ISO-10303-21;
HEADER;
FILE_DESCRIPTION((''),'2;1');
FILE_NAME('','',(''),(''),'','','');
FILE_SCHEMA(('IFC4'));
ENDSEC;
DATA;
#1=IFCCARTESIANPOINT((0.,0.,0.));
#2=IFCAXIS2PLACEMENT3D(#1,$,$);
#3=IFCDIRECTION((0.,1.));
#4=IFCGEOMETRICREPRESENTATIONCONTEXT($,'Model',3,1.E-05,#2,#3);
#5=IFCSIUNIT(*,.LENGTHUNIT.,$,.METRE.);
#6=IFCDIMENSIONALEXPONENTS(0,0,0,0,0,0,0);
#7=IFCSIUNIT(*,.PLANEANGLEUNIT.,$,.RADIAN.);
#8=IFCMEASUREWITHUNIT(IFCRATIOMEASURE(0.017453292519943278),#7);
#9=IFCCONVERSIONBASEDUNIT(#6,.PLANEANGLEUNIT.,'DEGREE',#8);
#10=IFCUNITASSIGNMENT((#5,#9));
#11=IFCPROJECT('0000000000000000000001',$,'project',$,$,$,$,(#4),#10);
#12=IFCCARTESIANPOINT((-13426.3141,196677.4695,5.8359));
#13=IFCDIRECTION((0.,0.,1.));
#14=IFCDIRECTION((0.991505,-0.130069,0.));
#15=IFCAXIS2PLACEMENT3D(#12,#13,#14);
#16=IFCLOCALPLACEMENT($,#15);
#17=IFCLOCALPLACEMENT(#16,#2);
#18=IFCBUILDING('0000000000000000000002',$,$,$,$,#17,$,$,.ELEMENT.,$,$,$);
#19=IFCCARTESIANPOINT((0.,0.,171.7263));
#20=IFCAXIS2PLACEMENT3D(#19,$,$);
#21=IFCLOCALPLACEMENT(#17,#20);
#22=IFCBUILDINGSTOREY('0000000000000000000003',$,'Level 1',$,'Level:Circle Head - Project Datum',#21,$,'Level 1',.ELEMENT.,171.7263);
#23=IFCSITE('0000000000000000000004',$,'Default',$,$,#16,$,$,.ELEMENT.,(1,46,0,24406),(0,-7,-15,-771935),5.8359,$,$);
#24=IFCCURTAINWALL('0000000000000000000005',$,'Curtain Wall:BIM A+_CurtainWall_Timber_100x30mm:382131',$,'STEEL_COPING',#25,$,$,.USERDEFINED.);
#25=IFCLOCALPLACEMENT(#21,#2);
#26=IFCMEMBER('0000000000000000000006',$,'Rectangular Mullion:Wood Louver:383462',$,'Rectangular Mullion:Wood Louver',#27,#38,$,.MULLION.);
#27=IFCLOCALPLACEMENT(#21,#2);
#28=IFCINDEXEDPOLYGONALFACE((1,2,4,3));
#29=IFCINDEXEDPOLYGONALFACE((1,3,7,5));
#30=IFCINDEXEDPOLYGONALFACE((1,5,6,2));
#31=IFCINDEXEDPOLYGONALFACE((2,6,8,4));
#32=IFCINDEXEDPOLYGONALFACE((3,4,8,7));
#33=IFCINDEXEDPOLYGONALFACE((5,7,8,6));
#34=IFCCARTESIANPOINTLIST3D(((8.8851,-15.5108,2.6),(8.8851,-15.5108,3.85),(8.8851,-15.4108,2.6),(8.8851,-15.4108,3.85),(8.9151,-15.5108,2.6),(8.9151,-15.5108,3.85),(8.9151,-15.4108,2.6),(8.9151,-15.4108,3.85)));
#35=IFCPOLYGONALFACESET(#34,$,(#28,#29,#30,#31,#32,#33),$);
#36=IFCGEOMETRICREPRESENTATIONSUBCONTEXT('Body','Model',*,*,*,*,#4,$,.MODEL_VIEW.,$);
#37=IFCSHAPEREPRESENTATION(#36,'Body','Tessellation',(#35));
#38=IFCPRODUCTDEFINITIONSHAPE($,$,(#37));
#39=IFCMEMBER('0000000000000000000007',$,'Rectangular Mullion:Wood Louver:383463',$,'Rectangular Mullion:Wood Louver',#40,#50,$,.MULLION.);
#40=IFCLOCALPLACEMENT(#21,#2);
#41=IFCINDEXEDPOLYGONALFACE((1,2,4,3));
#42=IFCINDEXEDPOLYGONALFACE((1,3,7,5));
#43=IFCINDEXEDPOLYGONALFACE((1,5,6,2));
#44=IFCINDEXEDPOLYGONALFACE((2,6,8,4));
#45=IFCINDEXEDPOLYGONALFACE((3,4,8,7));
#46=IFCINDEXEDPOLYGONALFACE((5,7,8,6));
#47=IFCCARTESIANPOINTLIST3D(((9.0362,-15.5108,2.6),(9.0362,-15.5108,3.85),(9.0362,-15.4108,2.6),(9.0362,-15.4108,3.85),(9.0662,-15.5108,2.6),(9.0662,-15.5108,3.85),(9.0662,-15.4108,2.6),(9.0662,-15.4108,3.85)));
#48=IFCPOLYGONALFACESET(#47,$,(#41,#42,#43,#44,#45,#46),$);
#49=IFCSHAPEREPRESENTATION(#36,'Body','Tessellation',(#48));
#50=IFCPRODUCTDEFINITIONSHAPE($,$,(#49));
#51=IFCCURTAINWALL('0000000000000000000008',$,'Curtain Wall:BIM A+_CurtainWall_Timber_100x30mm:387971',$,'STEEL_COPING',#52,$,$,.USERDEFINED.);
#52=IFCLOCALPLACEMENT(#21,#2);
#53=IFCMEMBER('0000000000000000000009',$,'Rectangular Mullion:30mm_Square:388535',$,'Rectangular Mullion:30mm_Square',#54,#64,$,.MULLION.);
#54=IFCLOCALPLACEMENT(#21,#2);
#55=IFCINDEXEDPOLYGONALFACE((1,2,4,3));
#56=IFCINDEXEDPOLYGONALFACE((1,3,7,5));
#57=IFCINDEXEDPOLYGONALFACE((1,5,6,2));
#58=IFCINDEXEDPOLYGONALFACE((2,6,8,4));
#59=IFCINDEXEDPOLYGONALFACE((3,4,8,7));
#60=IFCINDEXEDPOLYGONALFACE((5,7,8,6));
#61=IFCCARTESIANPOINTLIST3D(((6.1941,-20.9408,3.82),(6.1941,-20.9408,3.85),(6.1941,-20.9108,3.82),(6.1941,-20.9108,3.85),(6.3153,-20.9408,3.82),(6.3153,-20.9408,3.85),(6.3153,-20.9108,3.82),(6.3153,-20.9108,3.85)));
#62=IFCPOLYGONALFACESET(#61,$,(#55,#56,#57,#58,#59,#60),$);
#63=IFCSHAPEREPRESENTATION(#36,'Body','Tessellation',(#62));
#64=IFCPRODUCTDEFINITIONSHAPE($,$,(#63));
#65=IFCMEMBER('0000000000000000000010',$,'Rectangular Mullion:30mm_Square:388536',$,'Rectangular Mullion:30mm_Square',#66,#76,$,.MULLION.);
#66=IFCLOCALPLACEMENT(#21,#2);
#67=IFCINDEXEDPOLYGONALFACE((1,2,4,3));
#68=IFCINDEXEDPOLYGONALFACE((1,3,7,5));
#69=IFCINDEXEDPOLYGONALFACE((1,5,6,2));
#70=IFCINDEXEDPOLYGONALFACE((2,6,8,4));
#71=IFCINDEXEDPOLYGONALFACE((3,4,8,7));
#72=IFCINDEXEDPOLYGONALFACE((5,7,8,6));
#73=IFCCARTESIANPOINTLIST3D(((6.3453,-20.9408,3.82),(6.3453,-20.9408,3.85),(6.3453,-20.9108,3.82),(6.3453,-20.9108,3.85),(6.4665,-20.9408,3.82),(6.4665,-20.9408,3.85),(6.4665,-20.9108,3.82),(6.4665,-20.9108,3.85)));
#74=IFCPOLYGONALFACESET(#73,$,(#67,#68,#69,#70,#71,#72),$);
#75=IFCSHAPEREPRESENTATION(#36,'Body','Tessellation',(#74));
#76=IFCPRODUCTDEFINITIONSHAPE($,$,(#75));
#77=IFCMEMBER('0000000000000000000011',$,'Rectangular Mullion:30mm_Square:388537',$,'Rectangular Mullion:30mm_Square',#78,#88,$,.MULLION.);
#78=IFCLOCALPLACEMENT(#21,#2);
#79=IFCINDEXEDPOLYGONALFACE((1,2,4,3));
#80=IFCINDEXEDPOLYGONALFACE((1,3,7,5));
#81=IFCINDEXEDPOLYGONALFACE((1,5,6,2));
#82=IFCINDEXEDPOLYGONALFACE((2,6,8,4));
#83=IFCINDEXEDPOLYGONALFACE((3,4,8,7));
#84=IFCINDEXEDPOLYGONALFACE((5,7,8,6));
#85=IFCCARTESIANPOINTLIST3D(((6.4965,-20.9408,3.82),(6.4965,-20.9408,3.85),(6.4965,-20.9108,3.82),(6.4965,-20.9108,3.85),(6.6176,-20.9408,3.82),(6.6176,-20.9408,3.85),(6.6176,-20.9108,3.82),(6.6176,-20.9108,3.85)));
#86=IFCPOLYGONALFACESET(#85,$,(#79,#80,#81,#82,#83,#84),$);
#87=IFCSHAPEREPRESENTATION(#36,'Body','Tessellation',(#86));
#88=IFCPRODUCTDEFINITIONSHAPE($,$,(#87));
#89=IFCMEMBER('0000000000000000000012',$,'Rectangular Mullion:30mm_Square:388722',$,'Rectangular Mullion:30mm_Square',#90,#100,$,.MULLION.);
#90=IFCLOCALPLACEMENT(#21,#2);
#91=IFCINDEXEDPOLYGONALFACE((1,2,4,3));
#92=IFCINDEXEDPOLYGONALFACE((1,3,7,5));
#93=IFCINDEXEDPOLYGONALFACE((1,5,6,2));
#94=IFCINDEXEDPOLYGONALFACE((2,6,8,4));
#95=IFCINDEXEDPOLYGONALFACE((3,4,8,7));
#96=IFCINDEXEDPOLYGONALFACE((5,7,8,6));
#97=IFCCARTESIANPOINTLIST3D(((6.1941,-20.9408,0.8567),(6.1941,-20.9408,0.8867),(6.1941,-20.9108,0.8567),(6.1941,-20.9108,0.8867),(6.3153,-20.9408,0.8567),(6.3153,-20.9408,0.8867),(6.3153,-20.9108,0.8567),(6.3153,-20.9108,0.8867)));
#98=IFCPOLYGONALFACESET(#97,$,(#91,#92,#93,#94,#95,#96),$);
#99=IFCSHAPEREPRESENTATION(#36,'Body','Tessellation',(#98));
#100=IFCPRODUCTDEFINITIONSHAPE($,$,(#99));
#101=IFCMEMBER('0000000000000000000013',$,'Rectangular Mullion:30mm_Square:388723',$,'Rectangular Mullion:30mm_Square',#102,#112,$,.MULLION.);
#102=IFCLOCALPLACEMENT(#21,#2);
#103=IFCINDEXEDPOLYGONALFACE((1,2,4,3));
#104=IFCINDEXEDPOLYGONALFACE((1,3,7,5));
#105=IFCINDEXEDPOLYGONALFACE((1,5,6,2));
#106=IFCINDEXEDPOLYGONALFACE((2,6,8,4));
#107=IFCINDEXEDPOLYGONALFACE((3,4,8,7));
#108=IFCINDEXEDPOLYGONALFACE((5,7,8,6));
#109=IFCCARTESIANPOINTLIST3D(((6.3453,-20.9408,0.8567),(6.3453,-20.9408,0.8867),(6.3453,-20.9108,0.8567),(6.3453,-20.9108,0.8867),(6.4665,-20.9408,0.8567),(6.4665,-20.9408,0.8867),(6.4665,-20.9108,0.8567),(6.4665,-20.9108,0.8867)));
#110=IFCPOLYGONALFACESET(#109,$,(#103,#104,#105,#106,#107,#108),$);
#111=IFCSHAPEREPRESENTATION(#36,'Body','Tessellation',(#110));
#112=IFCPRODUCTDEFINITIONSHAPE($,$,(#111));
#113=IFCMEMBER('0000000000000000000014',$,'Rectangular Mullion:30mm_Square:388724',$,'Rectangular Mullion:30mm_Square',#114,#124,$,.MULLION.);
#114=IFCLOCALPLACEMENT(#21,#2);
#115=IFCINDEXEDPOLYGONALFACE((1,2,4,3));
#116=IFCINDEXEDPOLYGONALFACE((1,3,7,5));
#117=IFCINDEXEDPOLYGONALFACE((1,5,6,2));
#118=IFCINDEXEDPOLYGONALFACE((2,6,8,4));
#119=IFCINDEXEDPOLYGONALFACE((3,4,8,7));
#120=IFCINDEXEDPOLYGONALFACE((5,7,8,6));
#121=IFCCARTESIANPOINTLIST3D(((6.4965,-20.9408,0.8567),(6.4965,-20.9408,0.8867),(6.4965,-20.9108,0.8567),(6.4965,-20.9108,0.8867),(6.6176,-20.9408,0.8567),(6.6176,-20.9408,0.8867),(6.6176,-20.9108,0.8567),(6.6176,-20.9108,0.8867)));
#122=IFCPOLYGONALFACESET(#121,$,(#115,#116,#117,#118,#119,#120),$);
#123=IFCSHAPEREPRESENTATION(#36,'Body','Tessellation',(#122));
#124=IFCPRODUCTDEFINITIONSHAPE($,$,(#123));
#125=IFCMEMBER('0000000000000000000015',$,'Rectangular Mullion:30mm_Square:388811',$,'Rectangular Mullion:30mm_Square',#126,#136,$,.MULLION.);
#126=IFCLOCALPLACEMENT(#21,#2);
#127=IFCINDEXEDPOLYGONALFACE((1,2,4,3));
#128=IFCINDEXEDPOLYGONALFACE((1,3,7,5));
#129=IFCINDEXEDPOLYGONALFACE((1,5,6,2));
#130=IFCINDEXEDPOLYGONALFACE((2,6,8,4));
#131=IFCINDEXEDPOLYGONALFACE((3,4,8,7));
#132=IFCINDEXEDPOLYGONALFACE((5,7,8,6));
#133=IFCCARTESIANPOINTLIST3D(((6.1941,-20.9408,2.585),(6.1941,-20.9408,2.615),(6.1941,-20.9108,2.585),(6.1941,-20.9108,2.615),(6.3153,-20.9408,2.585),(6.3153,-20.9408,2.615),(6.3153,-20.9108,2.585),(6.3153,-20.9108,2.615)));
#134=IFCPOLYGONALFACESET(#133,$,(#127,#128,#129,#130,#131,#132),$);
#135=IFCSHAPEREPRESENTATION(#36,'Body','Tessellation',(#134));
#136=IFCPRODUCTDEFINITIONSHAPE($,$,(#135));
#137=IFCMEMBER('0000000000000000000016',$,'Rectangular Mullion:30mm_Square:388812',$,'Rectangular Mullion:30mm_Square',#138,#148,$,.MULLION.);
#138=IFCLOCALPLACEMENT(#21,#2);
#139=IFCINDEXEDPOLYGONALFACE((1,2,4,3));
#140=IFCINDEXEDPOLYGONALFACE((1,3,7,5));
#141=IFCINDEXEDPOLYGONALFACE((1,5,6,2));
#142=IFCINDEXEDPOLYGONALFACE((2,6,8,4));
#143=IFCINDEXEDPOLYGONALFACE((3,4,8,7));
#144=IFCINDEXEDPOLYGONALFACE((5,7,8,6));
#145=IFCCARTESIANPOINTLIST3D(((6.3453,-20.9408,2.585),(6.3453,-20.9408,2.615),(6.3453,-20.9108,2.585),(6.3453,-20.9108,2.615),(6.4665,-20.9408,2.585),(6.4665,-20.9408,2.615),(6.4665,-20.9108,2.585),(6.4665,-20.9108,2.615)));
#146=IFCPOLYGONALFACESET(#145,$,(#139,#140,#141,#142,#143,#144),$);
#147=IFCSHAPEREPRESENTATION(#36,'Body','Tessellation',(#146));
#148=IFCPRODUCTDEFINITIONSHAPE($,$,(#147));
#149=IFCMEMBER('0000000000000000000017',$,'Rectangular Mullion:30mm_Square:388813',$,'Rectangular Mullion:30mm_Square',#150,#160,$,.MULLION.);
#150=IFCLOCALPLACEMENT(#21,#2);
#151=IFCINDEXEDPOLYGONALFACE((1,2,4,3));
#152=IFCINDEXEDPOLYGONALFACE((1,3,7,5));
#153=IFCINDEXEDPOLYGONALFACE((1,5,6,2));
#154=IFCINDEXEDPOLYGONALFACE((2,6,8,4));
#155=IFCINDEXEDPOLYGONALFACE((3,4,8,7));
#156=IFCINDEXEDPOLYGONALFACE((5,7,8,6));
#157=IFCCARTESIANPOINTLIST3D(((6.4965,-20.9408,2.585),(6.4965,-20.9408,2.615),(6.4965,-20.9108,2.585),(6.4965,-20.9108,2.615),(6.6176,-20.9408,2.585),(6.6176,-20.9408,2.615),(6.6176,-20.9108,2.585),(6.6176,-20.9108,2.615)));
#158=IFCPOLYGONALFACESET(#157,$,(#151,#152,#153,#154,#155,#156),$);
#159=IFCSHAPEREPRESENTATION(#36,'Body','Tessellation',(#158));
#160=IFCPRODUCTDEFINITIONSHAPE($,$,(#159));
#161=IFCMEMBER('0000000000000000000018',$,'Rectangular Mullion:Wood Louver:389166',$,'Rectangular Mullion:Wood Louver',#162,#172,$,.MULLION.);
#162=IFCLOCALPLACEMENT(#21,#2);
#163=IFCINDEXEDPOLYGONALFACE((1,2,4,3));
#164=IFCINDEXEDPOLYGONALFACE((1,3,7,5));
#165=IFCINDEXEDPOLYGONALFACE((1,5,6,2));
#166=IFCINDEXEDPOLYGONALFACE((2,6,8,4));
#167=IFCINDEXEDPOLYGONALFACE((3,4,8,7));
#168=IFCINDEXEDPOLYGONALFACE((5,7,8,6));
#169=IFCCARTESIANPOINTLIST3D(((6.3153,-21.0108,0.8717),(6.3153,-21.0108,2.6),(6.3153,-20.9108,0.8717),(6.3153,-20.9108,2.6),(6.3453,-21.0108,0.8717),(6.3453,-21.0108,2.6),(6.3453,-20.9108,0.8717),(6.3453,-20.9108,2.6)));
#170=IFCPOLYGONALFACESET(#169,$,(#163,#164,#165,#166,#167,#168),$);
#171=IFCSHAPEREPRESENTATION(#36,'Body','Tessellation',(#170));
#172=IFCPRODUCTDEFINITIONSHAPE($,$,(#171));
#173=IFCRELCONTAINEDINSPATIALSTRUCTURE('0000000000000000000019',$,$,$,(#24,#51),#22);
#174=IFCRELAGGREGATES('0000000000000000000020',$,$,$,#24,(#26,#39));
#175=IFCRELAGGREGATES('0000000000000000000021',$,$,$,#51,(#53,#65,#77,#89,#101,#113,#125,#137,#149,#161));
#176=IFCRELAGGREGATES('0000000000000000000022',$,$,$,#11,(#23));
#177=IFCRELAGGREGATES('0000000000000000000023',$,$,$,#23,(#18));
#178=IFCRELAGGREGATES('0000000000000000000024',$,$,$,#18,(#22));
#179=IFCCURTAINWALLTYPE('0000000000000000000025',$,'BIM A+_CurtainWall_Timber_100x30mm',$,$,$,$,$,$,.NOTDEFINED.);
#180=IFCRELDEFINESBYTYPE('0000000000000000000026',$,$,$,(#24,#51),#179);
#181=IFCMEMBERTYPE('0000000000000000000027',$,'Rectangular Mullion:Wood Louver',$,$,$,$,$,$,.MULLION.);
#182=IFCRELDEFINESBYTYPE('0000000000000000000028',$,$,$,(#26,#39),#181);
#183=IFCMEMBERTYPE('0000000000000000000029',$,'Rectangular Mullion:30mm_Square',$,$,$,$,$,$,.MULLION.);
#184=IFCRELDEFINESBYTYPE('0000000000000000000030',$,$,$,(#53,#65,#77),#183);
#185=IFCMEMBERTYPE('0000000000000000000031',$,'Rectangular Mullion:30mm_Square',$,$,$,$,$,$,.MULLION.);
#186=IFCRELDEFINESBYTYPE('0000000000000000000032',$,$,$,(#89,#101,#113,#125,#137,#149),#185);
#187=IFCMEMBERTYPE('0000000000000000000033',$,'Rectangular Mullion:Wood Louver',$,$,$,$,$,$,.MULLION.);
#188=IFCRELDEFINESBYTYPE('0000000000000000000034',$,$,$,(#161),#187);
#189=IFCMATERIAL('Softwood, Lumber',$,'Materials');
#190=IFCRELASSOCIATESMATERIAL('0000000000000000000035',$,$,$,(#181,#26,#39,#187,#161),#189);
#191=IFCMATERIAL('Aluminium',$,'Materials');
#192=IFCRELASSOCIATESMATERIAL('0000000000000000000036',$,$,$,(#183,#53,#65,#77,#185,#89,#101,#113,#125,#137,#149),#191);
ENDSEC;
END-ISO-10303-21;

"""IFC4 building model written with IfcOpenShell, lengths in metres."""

from ifc_helpers import new_model, entity, si_unit, converted_unit, direction, frame, origin, place, context, subcontext, project, spatial, indexed_curve, outline, extrude, source, transform, mapped, material, type_object, type_shapes, element, aggregate, save


model = new_model("IFC4")

# Units and contexts
model_context = context("Model", 3, precision=1e-05, world=origin(), true_north=direction((0.0, 1.0)))
body_context = subcontext(model_context, "Body", "Model", "MODEL_VIEW")
ifc_project = project(units=[si_unit("LENGTHUNIT", "METRE"), converted_unit("PLANEANGLEUNIT", "DEGREE", entity("IfcRatioMeasure", 0.017453292519943278), si_unit("PLANEANGLEUNIT", "RADIAN"), dimensions=[0, 0, 0, 0, 0, 0, 0])], contexts=[model_context])

# Site, building, storey
site_placement = place(None, frame((-13426.3141, 196677.4695, 5.8359), z_axis=(0.0, 0.0, 1.0), x_axis=(0.991505, -0.130069, 0.0)))
site = spatial("IfcSite", under=ifc_project, at=site_placement, Name="Default", CompositionType="ELEMENT", RefLatitude=(1, 46, 0, 24406), RefLongitude=(0, -7, -15, -771935), RefElevation=5.8359)
building_placement = place(site_placement, origin())
building = spatial("IfcBuilding", under=site, at=building_placement, CompositionType="ELEMENT")
storey_placement = place(building_placement, frame((0.0, 0.0, 171.7263)))
storey = spatial("IfcBuildingStorey", under=building, at=storey_placement, Name="Level 1", ObjectType="Level:Circle Head - Project Datum", LongName="Level 1", CompositionType="ELEMENT", Elevation=171.7263)

# Curtain walls, members
ifc_material_1 = material(Name="Aluminium", Category="Materials")
curtain_wall_type_1 = type_object("IfcCurtainWallType", Name="BIM A+_CurtainWall_Timber_100x30mm", PredefinedType="NOTDEFINED")
curtain_wall_1_placement = place(storey_placement, frame((0.0, 0.0, -171.7263)))
curtain_wall_1 = element("IfcCurtainWall", 1, at=curtain_wall_1_placement, inside=storey, type_object=curtain_wall_type_1, Name="Curtain Wall:BIM A+_CurtainWall_Timber_100x30mm:382131", ObjectType="STEEL_COPING", PredefinedType="USERDEFINED")
ifc_material_2 = material(Name="Softwood, Lumber", Category="Materials")
member_type_1 = type_object("IfcMemberType", Name="Rectangular Mullion:Wood Louver", PredefinedType="MULLION", material=ifc_material_2)
shared_shape_1 = source(origin(), body_context, "Body", "SweptSolid", [
    extrude(outline(indexed_curve([(-0.05, -0.015), (0.05, -0.015), (0.05, 0.015), (-0.05, 0.015), (-0.05, -0.015)], self_intersect=False)), frame((0.0, -0.035, -1.25), z_axis=(0.0, 0.0, 1.0), x_axis=(0.0, -1.0, 0.0)), (0.0, 0.0, 1.0), 1.25),
])
type_shapes(member_type_1, [shared_shape_1])
member_1_placement = place(curtain_wall_1_placement, frame((8.9001, -15.4958, 174.3263), z_axis=(0.0, 0.0, -1.0), x_axis=(1.0, 0.0, 0.0)))
member_1 = element("IfcMember", 2, at=member_1_placement, type_object=member_type_1, material=ifc_material_2, Name="Rectangular Mullion:Wood Louver:383462", ObjectType="Rectangular Mullion:Wood Louver", PredefinedType="MULLION", context=body_context, shape_type="MappedRepresentation", body=[
    mapped(shared_shape_1, transform((0.0, 0.0, 0.0), scale=1.0)),
])
member_2_placement = place(curtain_wall_1_placement, frame((9.0512, -15.4958, 174.3263), z_axis=(0.0, 0.0, -1.0), x_axis=(1.0, 0.0, 0.0)))
member_2 = element("IfcMember", 3, at=member_2_placement, type_object=member_type_1, material=ifc_material_2, Name="Rectangular Mullion:Wood Louver:383463", ObjectType="Rectangular Mullion:Wood Louver", PredefinedType="MULLION", context=body_context, shape_type="MappedRepresentation", body=[
    mapped(shared_shape_1, transform((0.0, 0.0, 0.0), scale=1.0)),
])
curtain_wall_2_placement = place(storey_placement, frame((0.0, 0.0, -171.7263)))
curtain_wall_2 = element("IfcCurtainWall", 4, at=curtain_wall_2_placement, inside=storey, type_object=curtain_wall_type_1, Name="Curtain Wall:BIM A+_CurtainWall_Timber_100x30mm:387971", ObjectType="STEEL_COPING", PredefinedType="USERDEFINED")
member_type_2 = type_object("IfcMemberType", Name="Rectangular Mullion:30mm_Square", PredefinedType="MULLION", material=ifc_material_1)
shared_shape_2 = source(origin(), body_context, "Body", "SweptSolid", [
    extrude(outline(indexed_curve([(-0.015, -0.015), (0.015, -0.015), (0.015, 0.015), (-0.015, 0.015), (-0.015, -0.015)], self_intersect=False)), frame((-0.015, 0.0, -0.1212), z_axis=(0.0, 0.0, 1.0), x_axis=(0.0, -1.0, 0.0)), (0.0, 0.0, 1.0), 0.1212),
])
type_shapes(member_type_2, [shared_shape_2])
member_3_placement = place(curtain_wall_2_placement, frame((6.3153, -20.9258, 175.5763), z_axis=(1.0, 0.0, 0.0), x_axis=(0.0, 0.0, 1.0)))
member_3 = element("IfcMember", 5, at=member_3_placement, type_object=member_type_2, material=ifc_material_1, Name="Rectangular Mullion:30mm_Square:388535", ObjectType="Rectangular Mullion:30mm_Square", PredefinedType="MULLION", context=body_context, shape_type="MappedRepresentation", body=[
    mapped(shared_shape_2, transform((0.0, 0.0, 0.0), scale=1.0)),
])
member_4_placement = place(curtain_wall_2_placement, frame((6.4665, -20.9258, 175.5763), z_axis=(1.0, 0.0, 0.0), x_axis=(0.0, 0.0, 1.0)))
member_4 = element("IfcMember", 6, at=member_4_placement, type_object=member_type_2, material=ifc_material_1, Name="Rectangular Mullion:30mm_Square:388536", ObjectType="Rectangular Mullion:30mm_Square", PredefinedType="MULLION", context=body_context, shape_type="MappedRepresentation", body=[
    mapped(shared_shape_2, transform((0.0, 0.0, 0.0), scale=1.0)),
])
member_5_placement = place(curtain_wall_2_placement, frame((6.6176, -20.9258, 175.5763), z_axis=(1.0, 0.0, 0.0), x_axis=(0.0, 0.0, 1.0)))
member_5 = element("IfcMember", 7, at=member_5_placement, type_object=member_type_2, material=ifc_material_1, Name="Rectangular Mullion:30mm_Square:388537", ObjectType="Rectangular Mullion:30mm_Square", PredefinedType="MULLION", context=body_context, shape_type="MappedRepresentation", body=[
    mapped(shared_shape_2, transform((0.0, 0.0, 0.0), scale=1.0)),
])
member_type_3 = type_object("IfcMemberType", Name="Rectangular Mullion:30mm_Square", PredefinedType="MULLION", material=ifc_material_1)
shared_shape_3 = source(origin(), body_context, "Body", "SweptSolid", [
    extrude(outline(indexed_curve([(-0.015, -0.015), (0.015, -0.015), (0.015, 0.015), (-0.015, 0.015), (-0.015, -0.015)], self_intersect=False)), frame((0.0, 0.0, -0.1212), z_axis=(0.0, 0.0, 1.0), x_axis=(0.0, -1.0, 0.0)), (0.0, 0.0, 1.0), 0.1212),
])
type_shapes(member_type_3, [shared_shape_3])
member_6_placement = place(curtain_wall_2_placement, frame((6.3153, -20.9258, 172.598), z_axis=(1.0, 0.0, 0.0), x_axis=(0.0, 0.0, 1.0)))
member_6 = element("IfcMember", 8, at=member_6_placement, type_object=member_type_3, material=ifc_material_1, Name="Rectangular Mullion:30mm_Square:388722", ObjectType="Rectangular Mullion:30mm_Square", PredefinedType="MULLION", context=body_context, shape_type="MappedRepresentation", body=[
    mapped(shared_shape_3, transform((0.0, 0.0, 0.0), scale=1.0)),
])
member_7_placement = place(curtain_wall_2_placement, frame((6.4665, -20.9258, 172.598), z_axis=(1.0, 0.0, 0.0), x_axis=(0.0, 0.0, 1.0)))
member_7 = element("IfcMember", 9, at=member_7_placement, type_object=member_type_3, material=ifc_material_1, Name="Rectangular Mullion:30mm_Square:388723", ObjectType="Rectangular Mullion:30mm_Square", PredefinedType="MULLION", context=body_context, shape_type="MappedRepresentation", body=[
    mapped(shared_shape_3, transform((0.0, 0.0, 0.0), scale=1.0)),
])
member_8_placement = place(curtain_wall_2_placement, frame((6.6176, -20.9258, 172.598), z_axis=(1.0, 0.0, 0.0), x_axis=(0.0, 0.0, 1.0)))
member_8 = element("IfcMember", 10, at=member_8_placement, type_object=member_type_3, material=ifc_material_1, Name="Rectangular Mullion:30mm_Square:388724", ObjectType="Rectangular Mullion:30mm_Square", PredefinedType="MULLION", context=body_context, shape_type="MappedRepresentation", body=[
    mapped(shared_shape_3, transform((0.0, 0.0, 0.0), scale=1.0)),
])
member_9_placement = place(curtain_wall_2_placement, frame((6.3153, -20.9258, 174.3263), z_axis=(1.0, 0.0, 0.0), x_axis=(0.0, 0.0, 1.0)))
member_9 = element("IfcMember", 11, at=member_9_placement, type_object=member_type_3, material=ifc_material_1, Name="Rectangular Mullion:30mm_Square:388811", ObjectType="Rectangular Mullion:30mm_Square", PredefinedType="MULLION", context=body_context, shape_type="MappedRepresentation", body=[
    mapped(shared_shape_3, transform((0.0, 0.0, 0.0), scale=1.0)),
])
member_10_placement = place(curtain_wall_2_placement, frame((6.4665, -20.9258, 174.3263), z_axis=(1.0, 0.0, 0.0), x_axis=(0.0, 0.0, 1.0)))
member_10 = element("IfcMember", 12, at=member_10_placement, type_object=member_type_3, material=ifc_material_1, Name="Rectangular Mullion:30mm_Square:388812", ObjectType="Rectangular Mullion:30mm_Square", PredefinedType="MULLION", context=body_context, shape_type="MappedRepresentation", body=[
    mapped(shared_shape_3, transform((0.0, 0.0, 0.0), scale=1.0)),
])
member_11_placement = place(curtain_wall_2_placement, frame((6.6176, -20.9258, 174.3263), z_axis=(1.0, 0.0, 0.0), x_axis=(0.0, 0.0, 1.0)))
member_11 = element("IfcMember", 13, at=member_11_placement, type_object=member_type_3, material=ifc_material_1, Name="Rectangular Mullion:30mm_Square:388813", ObjectType="Rectangular Mullion:30mm_Square", PredefinedType="MULLION", context=body_context, shape_type="MappedRepresentation", body=[
    mapped(shared_shape_3, transform((0.0, 0.0, 0.0), scale=1.0)),
])
member_type_4 = type_object("IfcMemberType", Name="Rectangular Mullion:Wood Louver", PredefinedType="MULLION", material=ifc_material_2)
shared_shape_4 = source(origin(), body_context, "Body", "SweptSolid", [
    extrude(outline(indexed_curve([(-0.05, -0.015), (0.05, -0.015), (0.05, 0.015), (-0.05, 0.015), (-0.05, -0.015)], self_intersect=False)), frame((0.0, 0.035, -1.7283), z_axis=(0.0, 0.0, 1.0), x_axis=(0.0, -1.0, 0.0)), (0.0, 0.0, 1.0), 1.7283),
])
type_shapes(member_type_4, [shared_shape_4])
member_12_placement = place(curtain_wall_2_placement, frame((6.3303, -20.9258, 172.598), z_axis=(0.0, 0.0, -1.0), x_axis=(1.0, 0.0, 0.0)))
member_12 = element("IfcMember", 14, at=member_12_placement, type_object=member_type_4, material=ifc_material_2, Name="Rectangular Mullion:Wood Louver:389166", ObjectType="Rectangular Mullion:Wood Louver", PredefinedType="MULLION", context=body_context, shape_type="MappedRepresentation", body=[
    mapped(shared_shape_4, transform((0.0, 0.0, 0.0), scale=1.0)),
])

aggregate(curtain_wall_1, [member_1, member_2])
aggregate(curtain_wall_2, [member_3, member_4, member_5, member_6, member_7, member_8, member_9, member_10, member_11, member_12])

save(model, "model.ifc")
